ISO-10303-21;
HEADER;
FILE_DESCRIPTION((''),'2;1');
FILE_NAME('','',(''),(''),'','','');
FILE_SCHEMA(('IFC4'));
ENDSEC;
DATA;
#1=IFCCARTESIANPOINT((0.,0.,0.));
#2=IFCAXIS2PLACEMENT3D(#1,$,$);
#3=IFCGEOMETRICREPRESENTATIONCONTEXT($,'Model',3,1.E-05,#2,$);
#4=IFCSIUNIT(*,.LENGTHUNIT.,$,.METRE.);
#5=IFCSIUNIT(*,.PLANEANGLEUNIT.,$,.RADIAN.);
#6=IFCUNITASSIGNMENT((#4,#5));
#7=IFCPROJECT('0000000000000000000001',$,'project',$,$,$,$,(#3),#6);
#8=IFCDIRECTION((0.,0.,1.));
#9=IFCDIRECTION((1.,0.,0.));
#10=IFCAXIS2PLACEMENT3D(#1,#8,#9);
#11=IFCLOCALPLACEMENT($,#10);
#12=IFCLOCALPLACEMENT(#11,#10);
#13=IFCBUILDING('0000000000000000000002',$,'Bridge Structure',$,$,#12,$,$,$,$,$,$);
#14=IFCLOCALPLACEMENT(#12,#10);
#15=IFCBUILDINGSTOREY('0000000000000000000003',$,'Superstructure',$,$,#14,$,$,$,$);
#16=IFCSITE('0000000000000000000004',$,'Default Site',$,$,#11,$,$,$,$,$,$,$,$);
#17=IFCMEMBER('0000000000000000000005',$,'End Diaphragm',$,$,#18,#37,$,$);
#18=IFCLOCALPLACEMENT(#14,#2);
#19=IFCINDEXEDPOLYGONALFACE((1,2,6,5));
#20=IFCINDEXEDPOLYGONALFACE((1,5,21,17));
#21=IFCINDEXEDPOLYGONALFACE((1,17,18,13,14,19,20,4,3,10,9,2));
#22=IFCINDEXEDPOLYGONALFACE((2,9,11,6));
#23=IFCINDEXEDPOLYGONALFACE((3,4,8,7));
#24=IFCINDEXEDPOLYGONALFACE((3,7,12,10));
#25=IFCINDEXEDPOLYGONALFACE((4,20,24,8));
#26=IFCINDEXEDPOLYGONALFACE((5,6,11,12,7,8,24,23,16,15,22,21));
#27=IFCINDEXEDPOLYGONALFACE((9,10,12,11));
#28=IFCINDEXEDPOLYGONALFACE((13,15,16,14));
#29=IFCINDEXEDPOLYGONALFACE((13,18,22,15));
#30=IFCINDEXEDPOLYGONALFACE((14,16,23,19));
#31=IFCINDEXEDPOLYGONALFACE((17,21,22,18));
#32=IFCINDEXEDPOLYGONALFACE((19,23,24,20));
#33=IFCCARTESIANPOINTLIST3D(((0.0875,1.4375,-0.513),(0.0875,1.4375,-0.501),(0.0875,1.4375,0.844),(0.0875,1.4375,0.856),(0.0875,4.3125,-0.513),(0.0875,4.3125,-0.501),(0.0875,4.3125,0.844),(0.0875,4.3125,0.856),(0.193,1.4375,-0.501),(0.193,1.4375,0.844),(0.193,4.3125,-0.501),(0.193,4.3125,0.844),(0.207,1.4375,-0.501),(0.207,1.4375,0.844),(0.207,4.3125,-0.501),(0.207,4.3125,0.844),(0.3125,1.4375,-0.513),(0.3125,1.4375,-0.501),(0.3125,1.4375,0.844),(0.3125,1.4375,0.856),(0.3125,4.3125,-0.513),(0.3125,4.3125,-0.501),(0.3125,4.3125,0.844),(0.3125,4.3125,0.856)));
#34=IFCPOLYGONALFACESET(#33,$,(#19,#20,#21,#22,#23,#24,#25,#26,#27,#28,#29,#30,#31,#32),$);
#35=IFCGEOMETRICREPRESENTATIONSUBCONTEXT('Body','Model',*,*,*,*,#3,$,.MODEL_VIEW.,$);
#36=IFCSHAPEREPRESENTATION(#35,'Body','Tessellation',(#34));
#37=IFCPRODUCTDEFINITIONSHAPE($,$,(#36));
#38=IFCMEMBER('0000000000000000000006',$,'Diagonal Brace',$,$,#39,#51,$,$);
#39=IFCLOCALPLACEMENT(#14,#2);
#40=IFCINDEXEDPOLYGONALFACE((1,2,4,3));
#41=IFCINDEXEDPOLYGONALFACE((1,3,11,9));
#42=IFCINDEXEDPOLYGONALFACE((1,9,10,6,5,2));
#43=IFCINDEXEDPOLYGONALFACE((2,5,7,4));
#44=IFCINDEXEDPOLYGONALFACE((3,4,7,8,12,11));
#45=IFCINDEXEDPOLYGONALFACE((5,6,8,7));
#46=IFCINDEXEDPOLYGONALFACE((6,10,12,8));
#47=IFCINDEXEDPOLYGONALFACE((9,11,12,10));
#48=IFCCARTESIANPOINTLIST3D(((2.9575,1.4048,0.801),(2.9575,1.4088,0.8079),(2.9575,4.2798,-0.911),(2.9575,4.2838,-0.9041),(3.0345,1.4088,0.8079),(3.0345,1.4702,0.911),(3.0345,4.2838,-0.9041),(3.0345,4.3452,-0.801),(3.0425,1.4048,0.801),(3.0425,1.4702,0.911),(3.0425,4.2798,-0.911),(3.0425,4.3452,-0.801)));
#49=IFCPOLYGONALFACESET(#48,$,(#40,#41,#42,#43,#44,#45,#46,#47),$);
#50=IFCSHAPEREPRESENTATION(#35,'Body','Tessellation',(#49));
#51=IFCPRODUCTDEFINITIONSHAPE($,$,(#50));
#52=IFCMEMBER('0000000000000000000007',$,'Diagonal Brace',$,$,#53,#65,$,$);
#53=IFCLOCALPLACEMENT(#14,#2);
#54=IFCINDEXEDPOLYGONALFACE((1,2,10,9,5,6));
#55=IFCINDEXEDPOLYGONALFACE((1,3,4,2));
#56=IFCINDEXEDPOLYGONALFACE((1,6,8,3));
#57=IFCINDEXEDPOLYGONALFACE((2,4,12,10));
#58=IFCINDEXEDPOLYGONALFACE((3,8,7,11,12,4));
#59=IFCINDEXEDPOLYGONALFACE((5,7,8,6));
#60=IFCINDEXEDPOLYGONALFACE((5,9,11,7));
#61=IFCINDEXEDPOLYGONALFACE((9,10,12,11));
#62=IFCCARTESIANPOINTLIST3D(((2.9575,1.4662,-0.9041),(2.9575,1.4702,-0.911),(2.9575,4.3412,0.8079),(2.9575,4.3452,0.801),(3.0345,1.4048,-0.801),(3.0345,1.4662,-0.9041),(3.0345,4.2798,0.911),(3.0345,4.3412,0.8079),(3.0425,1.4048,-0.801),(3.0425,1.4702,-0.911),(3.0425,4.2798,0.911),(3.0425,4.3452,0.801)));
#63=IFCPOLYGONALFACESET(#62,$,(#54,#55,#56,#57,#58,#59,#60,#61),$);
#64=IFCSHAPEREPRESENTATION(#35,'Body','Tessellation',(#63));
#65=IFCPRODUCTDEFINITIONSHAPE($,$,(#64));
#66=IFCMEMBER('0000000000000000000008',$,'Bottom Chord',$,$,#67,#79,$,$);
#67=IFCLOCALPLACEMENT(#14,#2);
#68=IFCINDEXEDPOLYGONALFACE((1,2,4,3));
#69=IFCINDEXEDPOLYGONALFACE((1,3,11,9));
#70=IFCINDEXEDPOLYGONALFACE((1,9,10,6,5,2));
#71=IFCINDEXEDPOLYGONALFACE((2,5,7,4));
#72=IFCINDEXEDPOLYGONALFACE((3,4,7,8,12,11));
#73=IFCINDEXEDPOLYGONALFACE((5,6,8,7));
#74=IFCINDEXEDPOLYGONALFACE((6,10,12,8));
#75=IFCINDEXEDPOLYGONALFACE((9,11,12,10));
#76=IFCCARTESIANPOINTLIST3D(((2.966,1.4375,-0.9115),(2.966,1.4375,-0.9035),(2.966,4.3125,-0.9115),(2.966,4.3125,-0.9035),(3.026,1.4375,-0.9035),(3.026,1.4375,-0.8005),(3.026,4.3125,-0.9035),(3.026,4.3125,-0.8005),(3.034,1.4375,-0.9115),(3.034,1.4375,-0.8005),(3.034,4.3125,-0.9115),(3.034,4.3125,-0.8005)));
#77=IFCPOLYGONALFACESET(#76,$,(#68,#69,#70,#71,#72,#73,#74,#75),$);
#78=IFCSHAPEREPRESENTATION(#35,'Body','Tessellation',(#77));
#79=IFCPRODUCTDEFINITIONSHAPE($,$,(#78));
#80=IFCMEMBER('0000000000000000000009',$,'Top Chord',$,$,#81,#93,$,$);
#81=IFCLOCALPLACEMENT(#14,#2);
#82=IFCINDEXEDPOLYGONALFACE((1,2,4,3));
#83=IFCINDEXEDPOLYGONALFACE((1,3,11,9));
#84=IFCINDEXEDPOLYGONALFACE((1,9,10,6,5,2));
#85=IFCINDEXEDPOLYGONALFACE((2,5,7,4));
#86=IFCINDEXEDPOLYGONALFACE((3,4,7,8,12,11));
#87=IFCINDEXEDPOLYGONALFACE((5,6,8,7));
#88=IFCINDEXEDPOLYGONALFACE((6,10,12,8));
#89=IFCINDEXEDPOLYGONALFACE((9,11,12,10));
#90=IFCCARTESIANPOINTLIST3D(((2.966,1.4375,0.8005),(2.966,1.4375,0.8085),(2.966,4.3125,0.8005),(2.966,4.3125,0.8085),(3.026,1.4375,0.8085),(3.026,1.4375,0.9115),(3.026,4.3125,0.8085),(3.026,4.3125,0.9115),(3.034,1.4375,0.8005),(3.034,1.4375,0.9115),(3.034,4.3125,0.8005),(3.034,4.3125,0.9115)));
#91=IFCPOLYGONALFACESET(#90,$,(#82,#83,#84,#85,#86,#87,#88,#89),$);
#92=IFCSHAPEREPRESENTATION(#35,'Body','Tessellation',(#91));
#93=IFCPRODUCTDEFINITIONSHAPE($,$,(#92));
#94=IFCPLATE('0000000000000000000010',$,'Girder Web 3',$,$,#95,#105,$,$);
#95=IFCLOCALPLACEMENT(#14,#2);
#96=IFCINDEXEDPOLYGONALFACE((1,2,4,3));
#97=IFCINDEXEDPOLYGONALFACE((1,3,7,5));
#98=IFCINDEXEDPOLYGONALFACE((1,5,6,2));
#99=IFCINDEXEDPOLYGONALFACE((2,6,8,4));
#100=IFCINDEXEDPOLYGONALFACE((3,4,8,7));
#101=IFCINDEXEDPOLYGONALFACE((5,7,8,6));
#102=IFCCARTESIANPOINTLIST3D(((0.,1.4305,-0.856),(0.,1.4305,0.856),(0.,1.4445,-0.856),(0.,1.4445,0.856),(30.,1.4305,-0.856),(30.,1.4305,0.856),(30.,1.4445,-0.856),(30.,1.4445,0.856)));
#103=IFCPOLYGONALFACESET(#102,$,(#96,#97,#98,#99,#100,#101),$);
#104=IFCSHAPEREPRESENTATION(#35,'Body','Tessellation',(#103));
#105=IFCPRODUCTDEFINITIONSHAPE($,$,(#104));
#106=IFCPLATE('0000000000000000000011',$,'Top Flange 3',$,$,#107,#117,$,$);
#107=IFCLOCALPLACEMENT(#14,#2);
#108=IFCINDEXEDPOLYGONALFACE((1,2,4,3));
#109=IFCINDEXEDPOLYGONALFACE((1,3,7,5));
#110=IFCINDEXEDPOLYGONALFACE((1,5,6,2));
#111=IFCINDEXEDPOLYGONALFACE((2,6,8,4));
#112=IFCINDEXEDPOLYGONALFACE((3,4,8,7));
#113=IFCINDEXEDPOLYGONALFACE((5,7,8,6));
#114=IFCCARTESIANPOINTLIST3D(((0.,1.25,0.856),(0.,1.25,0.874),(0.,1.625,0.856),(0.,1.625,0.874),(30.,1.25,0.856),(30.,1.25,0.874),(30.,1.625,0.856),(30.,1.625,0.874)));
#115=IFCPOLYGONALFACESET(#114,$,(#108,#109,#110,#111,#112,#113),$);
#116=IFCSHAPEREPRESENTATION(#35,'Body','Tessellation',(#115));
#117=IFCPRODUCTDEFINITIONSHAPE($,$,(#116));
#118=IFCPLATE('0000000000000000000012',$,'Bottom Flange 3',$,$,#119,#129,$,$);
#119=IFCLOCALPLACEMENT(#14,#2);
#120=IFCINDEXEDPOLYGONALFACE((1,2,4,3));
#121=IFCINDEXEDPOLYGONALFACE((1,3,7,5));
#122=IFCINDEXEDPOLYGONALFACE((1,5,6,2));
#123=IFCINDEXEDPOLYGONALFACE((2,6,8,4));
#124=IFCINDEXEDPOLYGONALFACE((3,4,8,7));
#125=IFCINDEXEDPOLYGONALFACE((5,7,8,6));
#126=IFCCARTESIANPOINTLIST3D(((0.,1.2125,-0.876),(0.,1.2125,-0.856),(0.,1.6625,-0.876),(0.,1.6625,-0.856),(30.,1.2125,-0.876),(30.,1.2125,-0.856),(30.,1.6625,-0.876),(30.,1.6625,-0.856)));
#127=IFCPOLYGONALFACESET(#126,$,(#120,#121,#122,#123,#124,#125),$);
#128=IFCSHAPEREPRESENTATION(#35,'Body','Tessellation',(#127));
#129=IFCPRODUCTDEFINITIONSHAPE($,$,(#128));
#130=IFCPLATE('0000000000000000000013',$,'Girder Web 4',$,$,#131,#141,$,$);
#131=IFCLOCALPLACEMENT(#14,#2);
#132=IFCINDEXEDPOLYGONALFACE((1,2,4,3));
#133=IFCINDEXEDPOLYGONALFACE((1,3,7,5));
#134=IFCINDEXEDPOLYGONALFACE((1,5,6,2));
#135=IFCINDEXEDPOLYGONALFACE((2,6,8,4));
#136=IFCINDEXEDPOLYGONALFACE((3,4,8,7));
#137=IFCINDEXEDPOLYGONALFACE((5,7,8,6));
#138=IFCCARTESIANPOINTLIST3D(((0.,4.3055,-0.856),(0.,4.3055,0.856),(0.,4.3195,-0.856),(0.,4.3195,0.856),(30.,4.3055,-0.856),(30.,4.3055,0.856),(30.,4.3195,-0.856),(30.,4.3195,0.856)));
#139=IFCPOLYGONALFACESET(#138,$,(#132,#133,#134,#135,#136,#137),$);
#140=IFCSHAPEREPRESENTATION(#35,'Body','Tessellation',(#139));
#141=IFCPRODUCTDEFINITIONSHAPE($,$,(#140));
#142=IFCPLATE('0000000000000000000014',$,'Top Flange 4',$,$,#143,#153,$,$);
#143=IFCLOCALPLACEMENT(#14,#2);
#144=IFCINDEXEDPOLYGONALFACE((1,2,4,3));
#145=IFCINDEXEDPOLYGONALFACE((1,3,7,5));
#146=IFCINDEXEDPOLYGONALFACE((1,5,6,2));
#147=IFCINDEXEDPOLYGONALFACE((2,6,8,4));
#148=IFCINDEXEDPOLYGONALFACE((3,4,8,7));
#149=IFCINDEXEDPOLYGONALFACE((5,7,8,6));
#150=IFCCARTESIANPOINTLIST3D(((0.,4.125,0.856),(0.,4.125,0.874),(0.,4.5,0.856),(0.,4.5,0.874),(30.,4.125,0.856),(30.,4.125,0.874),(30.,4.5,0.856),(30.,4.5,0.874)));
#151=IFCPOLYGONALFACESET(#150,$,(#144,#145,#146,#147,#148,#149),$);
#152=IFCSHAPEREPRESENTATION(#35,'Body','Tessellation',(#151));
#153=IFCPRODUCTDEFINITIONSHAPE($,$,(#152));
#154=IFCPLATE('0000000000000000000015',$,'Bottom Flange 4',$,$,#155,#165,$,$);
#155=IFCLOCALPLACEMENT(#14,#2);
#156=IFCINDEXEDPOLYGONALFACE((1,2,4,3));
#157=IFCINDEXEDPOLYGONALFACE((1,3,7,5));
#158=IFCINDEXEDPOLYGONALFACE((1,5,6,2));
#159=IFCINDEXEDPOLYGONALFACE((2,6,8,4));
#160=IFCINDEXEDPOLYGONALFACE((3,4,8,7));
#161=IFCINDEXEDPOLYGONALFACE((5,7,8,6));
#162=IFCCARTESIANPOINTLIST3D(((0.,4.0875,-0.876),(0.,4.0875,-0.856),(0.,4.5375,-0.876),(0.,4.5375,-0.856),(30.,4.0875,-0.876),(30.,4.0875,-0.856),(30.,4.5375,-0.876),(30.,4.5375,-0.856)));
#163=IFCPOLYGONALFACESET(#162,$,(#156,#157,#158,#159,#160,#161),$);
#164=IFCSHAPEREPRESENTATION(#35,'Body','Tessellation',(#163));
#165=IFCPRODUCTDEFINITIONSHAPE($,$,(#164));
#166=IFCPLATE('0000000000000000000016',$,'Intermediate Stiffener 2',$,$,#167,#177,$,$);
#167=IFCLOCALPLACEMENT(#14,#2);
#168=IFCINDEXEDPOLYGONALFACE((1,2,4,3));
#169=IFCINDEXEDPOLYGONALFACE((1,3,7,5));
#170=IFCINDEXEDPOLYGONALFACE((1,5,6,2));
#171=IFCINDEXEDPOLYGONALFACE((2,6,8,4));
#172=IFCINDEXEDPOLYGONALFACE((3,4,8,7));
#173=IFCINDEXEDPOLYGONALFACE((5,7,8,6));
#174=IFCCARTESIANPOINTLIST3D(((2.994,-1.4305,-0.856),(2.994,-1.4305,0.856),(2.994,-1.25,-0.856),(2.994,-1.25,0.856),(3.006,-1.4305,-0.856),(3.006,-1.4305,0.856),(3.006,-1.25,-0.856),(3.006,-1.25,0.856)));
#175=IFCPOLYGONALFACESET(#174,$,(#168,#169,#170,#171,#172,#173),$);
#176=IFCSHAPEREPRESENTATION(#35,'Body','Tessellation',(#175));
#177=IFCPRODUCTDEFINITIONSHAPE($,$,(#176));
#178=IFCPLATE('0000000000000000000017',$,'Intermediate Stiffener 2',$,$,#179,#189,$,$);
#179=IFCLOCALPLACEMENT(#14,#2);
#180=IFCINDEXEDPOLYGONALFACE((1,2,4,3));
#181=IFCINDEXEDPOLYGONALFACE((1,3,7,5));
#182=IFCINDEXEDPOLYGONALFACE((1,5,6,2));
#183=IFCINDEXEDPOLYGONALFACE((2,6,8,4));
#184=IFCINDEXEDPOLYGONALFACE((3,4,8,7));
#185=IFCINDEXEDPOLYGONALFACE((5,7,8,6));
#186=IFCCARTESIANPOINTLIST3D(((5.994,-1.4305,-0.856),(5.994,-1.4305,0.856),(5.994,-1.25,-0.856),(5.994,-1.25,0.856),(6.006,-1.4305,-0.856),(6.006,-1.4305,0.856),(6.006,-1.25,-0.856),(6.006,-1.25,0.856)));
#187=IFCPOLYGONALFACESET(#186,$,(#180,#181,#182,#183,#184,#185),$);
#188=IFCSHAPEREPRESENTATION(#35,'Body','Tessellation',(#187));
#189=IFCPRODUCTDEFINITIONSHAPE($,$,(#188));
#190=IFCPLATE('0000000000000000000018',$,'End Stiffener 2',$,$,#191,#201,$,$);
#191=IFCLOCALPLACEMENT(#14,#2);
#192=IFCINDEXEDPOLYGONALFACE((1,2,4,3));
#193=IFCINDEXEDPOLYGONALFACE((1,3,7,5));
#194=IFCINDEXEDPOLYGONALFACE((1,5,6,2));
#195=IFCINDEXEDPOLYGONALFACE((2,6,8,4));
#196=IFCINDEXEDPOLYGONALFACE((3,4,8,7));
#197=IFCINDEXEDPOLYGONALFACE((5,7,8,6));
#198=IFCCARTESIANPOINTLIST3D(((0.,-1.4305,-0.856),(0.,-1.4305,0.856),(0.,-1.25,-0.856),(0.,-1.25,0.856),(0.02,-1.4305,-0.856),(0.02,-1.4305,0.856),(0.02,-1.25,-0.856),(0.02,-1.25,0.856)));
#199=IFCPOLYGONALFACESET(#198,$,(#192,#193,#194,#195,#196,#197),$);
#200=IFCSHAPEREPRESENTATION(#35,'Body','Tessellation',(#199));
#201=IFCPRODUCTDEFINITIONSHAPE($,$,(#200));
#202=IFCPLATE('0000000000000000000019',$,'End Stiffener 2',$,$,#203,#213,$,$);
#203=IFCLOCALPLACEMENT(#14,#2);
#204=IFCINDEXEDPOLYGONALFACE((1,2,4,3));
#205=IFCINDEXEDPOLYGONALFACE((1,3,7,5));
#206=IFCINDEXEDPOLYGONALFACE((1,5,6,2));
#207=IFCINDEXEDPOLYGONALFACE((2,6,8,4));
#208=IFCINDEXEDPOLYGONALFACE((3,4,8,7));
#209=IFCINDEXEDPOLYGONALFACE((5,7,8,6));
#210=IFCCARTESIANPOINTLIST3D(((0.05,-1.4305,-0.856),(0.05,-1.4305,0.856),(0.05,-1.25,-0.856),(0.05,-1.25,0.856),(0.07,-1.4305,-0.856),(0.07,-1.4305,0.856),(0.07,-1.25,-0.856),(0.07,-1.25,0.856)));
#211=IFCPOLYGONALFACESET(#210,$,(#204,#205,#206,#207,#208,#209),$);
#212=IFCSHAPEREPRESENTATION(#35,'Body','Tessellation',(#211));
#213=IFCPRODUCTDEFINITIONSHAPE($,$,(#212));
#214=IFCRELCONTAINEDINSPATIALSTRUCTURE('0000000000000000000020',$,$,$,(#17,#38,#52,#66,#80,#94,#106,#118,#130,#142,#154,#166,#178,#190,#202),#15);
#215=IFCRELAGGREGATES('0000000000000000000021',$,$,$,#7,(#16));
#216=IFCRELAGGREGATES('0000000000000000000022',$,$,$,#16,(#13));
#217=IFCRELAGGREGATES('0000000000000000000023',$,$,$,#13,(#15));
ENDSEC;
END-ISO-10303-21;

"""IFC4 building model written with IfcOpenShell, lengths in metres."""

from ifc_helpers import new_model, si_unit, frame, origin, origin_with_axes, origin_2d_with_axis, place, context, subcontext, project, spatial, rectangle, i_section, l_section, extrude, element, save


model = new_model("IFC4")

# Units and contexts
model_context = context("Model", 3, precision=1e-05, world=origin())
body_context = subcontext(model_context, "Body", "Model", "MODEL_VIEW")
ifc_project = project(units=[si_unit("LENGTHUNIT", "METRE"), si_unit("PLANEANGLEUNIT", "RADIAN")], contexts=[model_context])

# Site, building, storey
site_placement = place(None, origin_with_axes())
site = spatial("IfcSite", under=ifc_project, at=site_placement, Name="Default Site")
building_placement = place(site_placement, origin_with_axes())
building = spatial("IfcBuilding", under=site, at=building_placement, Name="Bridge Structure")
storey_placement = place(building_placement, origin_with_axes())
storey = spatial("IfcBuildingStorey", under=building, at=storey_placement, Name="Superstructure")

# Members
member_placement = place(storey_placement, frame((0.2, 1.4375, 0.1715), z_axis=(0.0, 1.0, 0.0), x_axis=(-1.0, 0.0, 0.0)))
element("IfcMember", 1, at=member_placement, inside=storey, Name="End Diaphragm", context=body_context, shape_type="SweptSolid", body=[
    extrude(i_section(OverallWidth=0.225, OverallDepth=1.369, WebThickness=0.014, FlangeThickness=0.012, at=origin_2d_with_axis()), origin_with_axes(), (0.0, 0.0, 1.0), 2.875),
])
for number, where, z_axis, x_axis, name in (
    (2, (3.0, 1.4375, 0.856), (0.0, 0.859202, -0.511636), (-1.0, 0.0, 0.0), "Diagonal Brace"),
    (3, (3.0, 1.4375, -0.856), (0.0, 0.859202, 0.511636), (-1.0, 0.0, 0.0), "Diagonal Brace"),
):
    element("IfcMember", number, at=place(storey_placement, frame(where, z_axis=z_axis, x_axis=x_axis)), inside=storey, Name=name, context=body_context, shape_type="SweptSolid", body=[
        extrude(l_section(Depth=0.128, Width=0.085, Thickness=0.008, at=origin_2d_with_axis()), origin_with_axes(), (0.0, 0.0, 1.0), 3.3461),
    ])
for number, where, z_axis, x_axis, name in (
    (4, (3.0, 1.4375, -0.856), (0.0, 1.0, 0.0), (-1.0, 0.0, 0.0), "Bottom Chord"),
    (5, (3.0, 1.4375, 0.856), (0.0, 1.0, 0.0), (-1.0, 0.0, 0.0), "Top Chord"),
):
    element("IfcMember", number, at=place(storey_placement, frame(where, z_axis=z_axis, x_axis=x_axis)), inside=storey, Name=name, context=body_context, shape_type="SweptSolid", body=[
        extrude(l_section(Depth=0.111, Width=0.068, Thickness=0.008, at=origin_2d_with_axis()), origin_with_axes(), (0.0, 0.0, 1.0), 2.875),
    ])

# Plates
plate_1_placement = place(storey_placement, frame((0.0, 1.4375, 0.0), z_axis=(1.0, 0.0, 0.0), x_axis=(0.0, 1.0, 0.0)))
element("IfcPlate", 6, at=plate_1_placement, inside=storey, Name="Girder Web 3", context=body_context, shape_type="SweptSolid", body=[
    extrude(rectangle(XDim=0.014, YDim=1.712, at=origin_2d_with_axis()), origin_with_axes(), (0.0, 0.0, 1.0), 30.0),
])
plate_2_placement = place(storey_placement, frame((0.0, 1.4375, 0.865), z_axis=(1.0, 0.0, 0.0), x_axis=(0.0, 1.0, 0.0)))
element("IfcPlate", 7, at=plate_2_placement, inside=storey, Name="Top Flange 3", context=body_context, shape_type="SweptSolid", body=[
    extrude(rectangle(XDim=0.375, YDim=0.018, at=origin_2d_with_axis()), origin_with_axes(), (0.0, 0.0, 1.0), 30.0),
])
plate_3_placement = place(storey_placement, frame((0.0, 1.4375, -0.866), z_axis=(1.0, 0.0, 0.0), x_axis=(0.0, 1.0, 0.0)))
element("IfcPlate", 8, at=plate_3_placement, inside=storey, Name="Bottom Flange 3", context=body_context, shape_type="SweptSolid", body=[
    extrude(rectangle(XDim=0.45, YDim=0.02, at=origin_2d_with_axis()), origin_with_axes(), (0.0, 0.0, 1.0), 30.0),
])
plate_4_placement = place(storey_placement, frame((0.0, 4.3125, 0.0), z_axis=(1.0, 0.0, 0.0), x_axis=(0.0, 1.0, 0.0)))
element("IfcPlate", 9, at=plate_4_placement, inside=storey, Name="Girder Web 4", context=body_context, shape_type="SweptSolid", body=[
    extrude(rectangle(XDim=0.014, YDim=1.712, at=origin_2d_with_axis()), origin_with_axes(), (0.0, 0.0, 1.0), 30.0),
])
plate_5_placement = place(storey_placement, frame((0.0, 4.3125, 0.865), z_axis=(1.0, 0.0, 0.0), x_axis=(0.0, 1.0, 0.0)))
element("IfcPlate", 10, at=plate_5_placement, inside=storey, Name="Top Flange 4", context=body_context, shape_type="SweptSolid", body=[
    extrude(rectangle(XDim=0.375, YDim=0.018, at=origin_2d_with_axis()), origin_with_axes(), (0.0, 0.0, 1.0), 30.0),
])
plate_6_placement = place(storey_placement, frame((0.0, 4.3125, -0.866), z_axis=(1.0, 0.0, 0.0), x_axis=(0.0, 1.0, 0.0)))
element("IfcPlate", 11, at=plate_6_placement, inside=storey, Name="Bottom Flange 4", context=body_context, shape_type="SweptSolid", body=[
    extrude(rectangle(XDim=0.45, YDim=0.02, at=origin_2d_with_axis()), origin_with_axes(), (0.0, 0.0, 1.0), 30.0),
])
for number, where, z_axis, x_axis, name in (
    (12, (3.0, -1.3402, -0.856), (0.0, 0.0, 1.0), (1.0, 0.0, 0.0), "Intermediate Stiffener 2"),
    (13, (6.0, -1.3402, -0.856), (0.0, 0.0, 1.0), (1.0, 0.0, 0.0), "Intermediate Stiffener 2"),
):
    element("IfcPlate", number, at=place(storey_placement, frame(where, z_axis=z_axis, x_axis=x_axis)), inside=storey, Name=name, context=body_context, shape_type="SweptSolid", body=[
        extrude(rectangle(XDim=0.012, YDim=0.1805, at=origin_2d_with_axis()), origin_with_axes(), (0.0, 0.0, 1.0), 1.712),
    ])
for number, where, z_axis, x_axis, name in (
    (14, (0.01, -1.3402, -0.856), (0.0, 0.0, 1.0), (1.0, 0.0, 0.0), "End Stiffener 2"),
    (15, (0.06, -1.3402, -0.856), (0.0, 0.0, 1.0), (1.0, 0.0, 0.0), "End Stiffener 2"),
):
    element("IfcPlate", number, at=place(storey_placement, frame(where, z_axis=z_axis, x_axis=x_axis)), inside=storey, Name=name, context=body_context, shape_type="SweptSolid", body=[
        extrude(rectangle(XDim=0.02, YDim=0.1805, at=origin_2d_with_axis()), origin_with_axes(), (0.0, 0.0, 1.0), 1.712),
    ])

save(model, "model.ifc")
